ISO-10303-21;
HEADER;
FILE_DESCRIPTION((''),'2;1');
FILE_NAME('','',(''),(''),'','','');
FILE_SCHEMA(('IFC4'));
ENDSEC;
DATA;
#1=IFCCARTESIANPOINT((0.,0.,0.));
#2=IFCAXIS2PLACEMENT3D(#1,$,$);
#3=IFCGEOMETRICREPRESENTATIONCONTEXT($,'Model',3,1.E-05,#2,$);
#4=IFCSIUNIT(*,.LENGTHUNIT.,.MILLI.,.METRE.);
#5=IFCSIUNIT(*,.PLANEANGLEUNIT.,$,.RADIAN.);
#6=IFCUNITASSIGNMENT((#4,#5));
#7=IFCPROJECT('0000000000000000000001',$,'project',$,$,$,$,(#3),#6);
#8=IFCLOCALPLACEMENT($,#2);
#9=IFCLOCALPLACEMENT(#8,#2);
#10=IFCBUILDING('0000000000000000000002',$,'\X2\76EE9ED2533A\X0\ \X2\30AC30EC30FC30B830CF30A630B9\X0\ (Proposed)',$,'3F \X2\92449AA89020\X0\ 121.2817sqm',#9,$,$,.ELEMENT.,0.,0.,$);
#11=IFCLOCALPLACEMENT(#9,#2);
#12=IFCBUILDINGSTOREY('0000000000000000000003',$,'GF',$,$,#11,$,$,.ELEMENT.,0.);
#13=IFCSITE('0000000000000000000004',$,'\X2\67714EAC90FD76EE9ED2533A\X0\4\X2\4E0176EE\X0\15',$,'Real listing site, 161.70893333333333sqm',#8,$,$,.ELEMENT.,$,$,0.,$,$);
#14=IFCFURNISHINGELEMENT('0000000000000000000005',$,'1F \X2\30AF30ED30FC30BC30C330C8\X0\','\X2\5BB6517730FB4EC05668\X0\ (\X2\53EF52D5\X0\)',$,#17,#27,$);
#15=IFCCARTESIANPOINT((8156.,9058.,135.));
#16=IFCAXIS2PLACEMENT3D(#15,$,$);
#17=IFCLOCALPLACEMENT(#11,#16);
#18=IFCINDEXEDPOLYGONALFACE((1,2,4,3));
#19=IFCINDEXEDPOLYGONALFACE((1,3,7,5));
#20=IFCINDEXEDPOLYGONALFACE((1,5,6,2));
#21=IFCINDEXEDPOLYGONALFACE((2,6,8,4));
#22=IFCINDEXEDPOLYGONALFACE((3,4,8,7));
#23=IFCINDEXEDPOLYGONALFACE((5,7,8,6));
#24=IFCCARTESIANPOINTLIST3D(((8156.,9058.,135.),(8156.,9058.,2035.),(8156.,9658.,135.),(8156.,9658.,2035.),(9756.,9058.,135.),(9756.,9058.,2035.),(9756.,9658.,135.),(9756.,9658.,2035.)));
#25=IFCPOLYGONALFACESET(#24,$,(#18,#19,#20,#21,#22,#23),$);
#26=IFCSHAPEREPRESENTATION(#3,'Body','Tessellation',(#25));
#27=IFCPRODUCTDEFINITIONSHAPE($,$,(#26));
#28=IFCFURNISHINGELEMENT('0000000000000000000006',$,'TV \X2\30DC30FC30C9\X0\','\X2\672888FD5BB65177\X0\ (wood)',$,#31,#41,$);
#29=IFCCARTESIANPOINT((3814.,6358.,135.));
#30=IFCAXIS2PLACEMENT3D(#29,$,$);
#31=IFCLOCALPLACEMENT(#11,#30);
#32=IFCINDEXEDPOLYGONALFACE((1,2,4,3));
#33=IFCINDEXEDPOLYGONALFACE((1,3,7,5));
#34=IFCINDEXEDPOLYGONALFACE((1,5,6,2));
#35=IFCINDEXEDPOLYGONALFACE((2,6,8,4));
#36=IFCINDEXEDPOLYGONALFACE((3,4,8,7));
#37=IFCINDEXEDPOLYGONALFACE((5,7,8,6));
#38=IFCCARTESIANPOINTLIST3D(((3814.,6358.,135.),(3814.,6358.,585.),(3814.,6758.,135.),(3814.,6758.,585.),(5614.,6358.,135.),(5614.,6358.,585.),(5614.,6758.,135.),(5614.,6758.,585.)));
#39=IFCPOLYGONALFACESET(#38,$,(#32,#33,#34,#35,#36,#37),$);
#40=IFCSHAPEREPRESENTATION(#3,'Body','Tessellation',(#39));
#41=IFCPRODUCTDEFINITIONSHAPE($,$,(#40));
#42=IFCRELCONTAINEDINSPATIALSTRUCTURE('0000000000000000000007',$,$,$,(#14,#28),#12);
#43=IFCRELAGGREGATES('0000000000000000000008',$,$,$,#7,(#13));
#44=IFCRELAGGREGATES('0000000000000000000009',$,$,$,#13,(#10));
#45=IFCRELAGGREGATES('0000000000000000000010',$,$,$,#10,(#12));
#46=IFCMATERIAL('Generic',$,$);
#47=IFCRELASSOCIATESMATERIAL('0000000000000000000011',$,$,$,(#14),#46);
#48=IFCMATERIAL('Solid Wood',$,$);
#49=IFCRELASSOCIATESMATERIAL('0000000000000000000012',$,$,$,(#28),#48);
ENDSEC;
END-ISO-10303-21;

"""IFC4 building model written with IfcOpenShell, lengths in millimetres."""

from ifc_helpers import new_model, si_unit, frame, frame_2d, origin, place, context, project, spatial, rectangle, extrude, material, element, save


model = new_model("IFC4")

# Units and contexts
model_context = context("Model", 3, precision=1e-05, world=origin())
ifc_project = project(units=[si_unit("LENGTHUNIT", "METRE", prefix="MILLI"), si_unit("PLANEANGLEUNIT", "RADIAN")], contexts=[model_context])

# Site, building, storey
site_placement = place(None, origin())
site = spatial("IfcSite", under=ifc_project, at=site_placement, Name="東京都目黒区4丁目15", ObjectType="Real listing site, 161.70893333333333sqm", CompositionType="ELEMENT", RefElevation=0.0)
building_placement = place(site_placement, origin())
building = spatial("IfcBuilding", under=site, at=building_placement, Name="目黒区 ガレージハウス (Proposed)", ObjectType="3F 鉄骨造 121.2817sqm", CompositionType="ELEMENT", ElevationOfRefHeight=0.0, ElevationOfTerrain=0.0)
storey_placement = place(building_placement, origin())
storey = spatial("IfcBuildingStorey", under=building, at=storey_placement, Name="GF", CompositionType="ELEMENT", Elevation=0.0)

# Shared definitions
ifc_material_1 = material(Name="Solid Wood")

# Shared definitions
ifc_material_2 = material(Name="Generic")

# Furnishing elements
furnishing_1_placement = place(storey_placement, frame((8156.0, 9058.0, 135.0)))
element("IfcFurnishingElement", 1, at=furnishing_1_placement, inside=storey, material=ifc_material_2, Name="1F クローゼット", Description="家具・什器 (可動)", context=model_context, shape_type="SweptSolid", body=[
    extrude(rectangle(XDim=1600.0, YDim=600.0, at=frame_2d((800.0, 300.0))), frame((8156.0, 9058.0, 135.0)), (0.0, 0.0, 1.0), 1900.0),
])
furnishing_2_placement = place(storey_placement, frame((3814.0, 6358.0, 135.0)))
element("IfcFurnishingElement", 2, at=furnishing_2_placement, inside=storey, material=ifc_material_1, Name="TV ボード", Description="木製家具 (wood)", context=model_context, shape_type="SweptSolid", body=[
    extrude(rectangle(XDim=1800.0, YDim=400.0, at=frame_2d((900.0, 200.0))), frame((3814.0, 6358.0, 135.0)), (0.0, 0.0, 1.0), 450.0),
])

save(model, "model.ifc")
